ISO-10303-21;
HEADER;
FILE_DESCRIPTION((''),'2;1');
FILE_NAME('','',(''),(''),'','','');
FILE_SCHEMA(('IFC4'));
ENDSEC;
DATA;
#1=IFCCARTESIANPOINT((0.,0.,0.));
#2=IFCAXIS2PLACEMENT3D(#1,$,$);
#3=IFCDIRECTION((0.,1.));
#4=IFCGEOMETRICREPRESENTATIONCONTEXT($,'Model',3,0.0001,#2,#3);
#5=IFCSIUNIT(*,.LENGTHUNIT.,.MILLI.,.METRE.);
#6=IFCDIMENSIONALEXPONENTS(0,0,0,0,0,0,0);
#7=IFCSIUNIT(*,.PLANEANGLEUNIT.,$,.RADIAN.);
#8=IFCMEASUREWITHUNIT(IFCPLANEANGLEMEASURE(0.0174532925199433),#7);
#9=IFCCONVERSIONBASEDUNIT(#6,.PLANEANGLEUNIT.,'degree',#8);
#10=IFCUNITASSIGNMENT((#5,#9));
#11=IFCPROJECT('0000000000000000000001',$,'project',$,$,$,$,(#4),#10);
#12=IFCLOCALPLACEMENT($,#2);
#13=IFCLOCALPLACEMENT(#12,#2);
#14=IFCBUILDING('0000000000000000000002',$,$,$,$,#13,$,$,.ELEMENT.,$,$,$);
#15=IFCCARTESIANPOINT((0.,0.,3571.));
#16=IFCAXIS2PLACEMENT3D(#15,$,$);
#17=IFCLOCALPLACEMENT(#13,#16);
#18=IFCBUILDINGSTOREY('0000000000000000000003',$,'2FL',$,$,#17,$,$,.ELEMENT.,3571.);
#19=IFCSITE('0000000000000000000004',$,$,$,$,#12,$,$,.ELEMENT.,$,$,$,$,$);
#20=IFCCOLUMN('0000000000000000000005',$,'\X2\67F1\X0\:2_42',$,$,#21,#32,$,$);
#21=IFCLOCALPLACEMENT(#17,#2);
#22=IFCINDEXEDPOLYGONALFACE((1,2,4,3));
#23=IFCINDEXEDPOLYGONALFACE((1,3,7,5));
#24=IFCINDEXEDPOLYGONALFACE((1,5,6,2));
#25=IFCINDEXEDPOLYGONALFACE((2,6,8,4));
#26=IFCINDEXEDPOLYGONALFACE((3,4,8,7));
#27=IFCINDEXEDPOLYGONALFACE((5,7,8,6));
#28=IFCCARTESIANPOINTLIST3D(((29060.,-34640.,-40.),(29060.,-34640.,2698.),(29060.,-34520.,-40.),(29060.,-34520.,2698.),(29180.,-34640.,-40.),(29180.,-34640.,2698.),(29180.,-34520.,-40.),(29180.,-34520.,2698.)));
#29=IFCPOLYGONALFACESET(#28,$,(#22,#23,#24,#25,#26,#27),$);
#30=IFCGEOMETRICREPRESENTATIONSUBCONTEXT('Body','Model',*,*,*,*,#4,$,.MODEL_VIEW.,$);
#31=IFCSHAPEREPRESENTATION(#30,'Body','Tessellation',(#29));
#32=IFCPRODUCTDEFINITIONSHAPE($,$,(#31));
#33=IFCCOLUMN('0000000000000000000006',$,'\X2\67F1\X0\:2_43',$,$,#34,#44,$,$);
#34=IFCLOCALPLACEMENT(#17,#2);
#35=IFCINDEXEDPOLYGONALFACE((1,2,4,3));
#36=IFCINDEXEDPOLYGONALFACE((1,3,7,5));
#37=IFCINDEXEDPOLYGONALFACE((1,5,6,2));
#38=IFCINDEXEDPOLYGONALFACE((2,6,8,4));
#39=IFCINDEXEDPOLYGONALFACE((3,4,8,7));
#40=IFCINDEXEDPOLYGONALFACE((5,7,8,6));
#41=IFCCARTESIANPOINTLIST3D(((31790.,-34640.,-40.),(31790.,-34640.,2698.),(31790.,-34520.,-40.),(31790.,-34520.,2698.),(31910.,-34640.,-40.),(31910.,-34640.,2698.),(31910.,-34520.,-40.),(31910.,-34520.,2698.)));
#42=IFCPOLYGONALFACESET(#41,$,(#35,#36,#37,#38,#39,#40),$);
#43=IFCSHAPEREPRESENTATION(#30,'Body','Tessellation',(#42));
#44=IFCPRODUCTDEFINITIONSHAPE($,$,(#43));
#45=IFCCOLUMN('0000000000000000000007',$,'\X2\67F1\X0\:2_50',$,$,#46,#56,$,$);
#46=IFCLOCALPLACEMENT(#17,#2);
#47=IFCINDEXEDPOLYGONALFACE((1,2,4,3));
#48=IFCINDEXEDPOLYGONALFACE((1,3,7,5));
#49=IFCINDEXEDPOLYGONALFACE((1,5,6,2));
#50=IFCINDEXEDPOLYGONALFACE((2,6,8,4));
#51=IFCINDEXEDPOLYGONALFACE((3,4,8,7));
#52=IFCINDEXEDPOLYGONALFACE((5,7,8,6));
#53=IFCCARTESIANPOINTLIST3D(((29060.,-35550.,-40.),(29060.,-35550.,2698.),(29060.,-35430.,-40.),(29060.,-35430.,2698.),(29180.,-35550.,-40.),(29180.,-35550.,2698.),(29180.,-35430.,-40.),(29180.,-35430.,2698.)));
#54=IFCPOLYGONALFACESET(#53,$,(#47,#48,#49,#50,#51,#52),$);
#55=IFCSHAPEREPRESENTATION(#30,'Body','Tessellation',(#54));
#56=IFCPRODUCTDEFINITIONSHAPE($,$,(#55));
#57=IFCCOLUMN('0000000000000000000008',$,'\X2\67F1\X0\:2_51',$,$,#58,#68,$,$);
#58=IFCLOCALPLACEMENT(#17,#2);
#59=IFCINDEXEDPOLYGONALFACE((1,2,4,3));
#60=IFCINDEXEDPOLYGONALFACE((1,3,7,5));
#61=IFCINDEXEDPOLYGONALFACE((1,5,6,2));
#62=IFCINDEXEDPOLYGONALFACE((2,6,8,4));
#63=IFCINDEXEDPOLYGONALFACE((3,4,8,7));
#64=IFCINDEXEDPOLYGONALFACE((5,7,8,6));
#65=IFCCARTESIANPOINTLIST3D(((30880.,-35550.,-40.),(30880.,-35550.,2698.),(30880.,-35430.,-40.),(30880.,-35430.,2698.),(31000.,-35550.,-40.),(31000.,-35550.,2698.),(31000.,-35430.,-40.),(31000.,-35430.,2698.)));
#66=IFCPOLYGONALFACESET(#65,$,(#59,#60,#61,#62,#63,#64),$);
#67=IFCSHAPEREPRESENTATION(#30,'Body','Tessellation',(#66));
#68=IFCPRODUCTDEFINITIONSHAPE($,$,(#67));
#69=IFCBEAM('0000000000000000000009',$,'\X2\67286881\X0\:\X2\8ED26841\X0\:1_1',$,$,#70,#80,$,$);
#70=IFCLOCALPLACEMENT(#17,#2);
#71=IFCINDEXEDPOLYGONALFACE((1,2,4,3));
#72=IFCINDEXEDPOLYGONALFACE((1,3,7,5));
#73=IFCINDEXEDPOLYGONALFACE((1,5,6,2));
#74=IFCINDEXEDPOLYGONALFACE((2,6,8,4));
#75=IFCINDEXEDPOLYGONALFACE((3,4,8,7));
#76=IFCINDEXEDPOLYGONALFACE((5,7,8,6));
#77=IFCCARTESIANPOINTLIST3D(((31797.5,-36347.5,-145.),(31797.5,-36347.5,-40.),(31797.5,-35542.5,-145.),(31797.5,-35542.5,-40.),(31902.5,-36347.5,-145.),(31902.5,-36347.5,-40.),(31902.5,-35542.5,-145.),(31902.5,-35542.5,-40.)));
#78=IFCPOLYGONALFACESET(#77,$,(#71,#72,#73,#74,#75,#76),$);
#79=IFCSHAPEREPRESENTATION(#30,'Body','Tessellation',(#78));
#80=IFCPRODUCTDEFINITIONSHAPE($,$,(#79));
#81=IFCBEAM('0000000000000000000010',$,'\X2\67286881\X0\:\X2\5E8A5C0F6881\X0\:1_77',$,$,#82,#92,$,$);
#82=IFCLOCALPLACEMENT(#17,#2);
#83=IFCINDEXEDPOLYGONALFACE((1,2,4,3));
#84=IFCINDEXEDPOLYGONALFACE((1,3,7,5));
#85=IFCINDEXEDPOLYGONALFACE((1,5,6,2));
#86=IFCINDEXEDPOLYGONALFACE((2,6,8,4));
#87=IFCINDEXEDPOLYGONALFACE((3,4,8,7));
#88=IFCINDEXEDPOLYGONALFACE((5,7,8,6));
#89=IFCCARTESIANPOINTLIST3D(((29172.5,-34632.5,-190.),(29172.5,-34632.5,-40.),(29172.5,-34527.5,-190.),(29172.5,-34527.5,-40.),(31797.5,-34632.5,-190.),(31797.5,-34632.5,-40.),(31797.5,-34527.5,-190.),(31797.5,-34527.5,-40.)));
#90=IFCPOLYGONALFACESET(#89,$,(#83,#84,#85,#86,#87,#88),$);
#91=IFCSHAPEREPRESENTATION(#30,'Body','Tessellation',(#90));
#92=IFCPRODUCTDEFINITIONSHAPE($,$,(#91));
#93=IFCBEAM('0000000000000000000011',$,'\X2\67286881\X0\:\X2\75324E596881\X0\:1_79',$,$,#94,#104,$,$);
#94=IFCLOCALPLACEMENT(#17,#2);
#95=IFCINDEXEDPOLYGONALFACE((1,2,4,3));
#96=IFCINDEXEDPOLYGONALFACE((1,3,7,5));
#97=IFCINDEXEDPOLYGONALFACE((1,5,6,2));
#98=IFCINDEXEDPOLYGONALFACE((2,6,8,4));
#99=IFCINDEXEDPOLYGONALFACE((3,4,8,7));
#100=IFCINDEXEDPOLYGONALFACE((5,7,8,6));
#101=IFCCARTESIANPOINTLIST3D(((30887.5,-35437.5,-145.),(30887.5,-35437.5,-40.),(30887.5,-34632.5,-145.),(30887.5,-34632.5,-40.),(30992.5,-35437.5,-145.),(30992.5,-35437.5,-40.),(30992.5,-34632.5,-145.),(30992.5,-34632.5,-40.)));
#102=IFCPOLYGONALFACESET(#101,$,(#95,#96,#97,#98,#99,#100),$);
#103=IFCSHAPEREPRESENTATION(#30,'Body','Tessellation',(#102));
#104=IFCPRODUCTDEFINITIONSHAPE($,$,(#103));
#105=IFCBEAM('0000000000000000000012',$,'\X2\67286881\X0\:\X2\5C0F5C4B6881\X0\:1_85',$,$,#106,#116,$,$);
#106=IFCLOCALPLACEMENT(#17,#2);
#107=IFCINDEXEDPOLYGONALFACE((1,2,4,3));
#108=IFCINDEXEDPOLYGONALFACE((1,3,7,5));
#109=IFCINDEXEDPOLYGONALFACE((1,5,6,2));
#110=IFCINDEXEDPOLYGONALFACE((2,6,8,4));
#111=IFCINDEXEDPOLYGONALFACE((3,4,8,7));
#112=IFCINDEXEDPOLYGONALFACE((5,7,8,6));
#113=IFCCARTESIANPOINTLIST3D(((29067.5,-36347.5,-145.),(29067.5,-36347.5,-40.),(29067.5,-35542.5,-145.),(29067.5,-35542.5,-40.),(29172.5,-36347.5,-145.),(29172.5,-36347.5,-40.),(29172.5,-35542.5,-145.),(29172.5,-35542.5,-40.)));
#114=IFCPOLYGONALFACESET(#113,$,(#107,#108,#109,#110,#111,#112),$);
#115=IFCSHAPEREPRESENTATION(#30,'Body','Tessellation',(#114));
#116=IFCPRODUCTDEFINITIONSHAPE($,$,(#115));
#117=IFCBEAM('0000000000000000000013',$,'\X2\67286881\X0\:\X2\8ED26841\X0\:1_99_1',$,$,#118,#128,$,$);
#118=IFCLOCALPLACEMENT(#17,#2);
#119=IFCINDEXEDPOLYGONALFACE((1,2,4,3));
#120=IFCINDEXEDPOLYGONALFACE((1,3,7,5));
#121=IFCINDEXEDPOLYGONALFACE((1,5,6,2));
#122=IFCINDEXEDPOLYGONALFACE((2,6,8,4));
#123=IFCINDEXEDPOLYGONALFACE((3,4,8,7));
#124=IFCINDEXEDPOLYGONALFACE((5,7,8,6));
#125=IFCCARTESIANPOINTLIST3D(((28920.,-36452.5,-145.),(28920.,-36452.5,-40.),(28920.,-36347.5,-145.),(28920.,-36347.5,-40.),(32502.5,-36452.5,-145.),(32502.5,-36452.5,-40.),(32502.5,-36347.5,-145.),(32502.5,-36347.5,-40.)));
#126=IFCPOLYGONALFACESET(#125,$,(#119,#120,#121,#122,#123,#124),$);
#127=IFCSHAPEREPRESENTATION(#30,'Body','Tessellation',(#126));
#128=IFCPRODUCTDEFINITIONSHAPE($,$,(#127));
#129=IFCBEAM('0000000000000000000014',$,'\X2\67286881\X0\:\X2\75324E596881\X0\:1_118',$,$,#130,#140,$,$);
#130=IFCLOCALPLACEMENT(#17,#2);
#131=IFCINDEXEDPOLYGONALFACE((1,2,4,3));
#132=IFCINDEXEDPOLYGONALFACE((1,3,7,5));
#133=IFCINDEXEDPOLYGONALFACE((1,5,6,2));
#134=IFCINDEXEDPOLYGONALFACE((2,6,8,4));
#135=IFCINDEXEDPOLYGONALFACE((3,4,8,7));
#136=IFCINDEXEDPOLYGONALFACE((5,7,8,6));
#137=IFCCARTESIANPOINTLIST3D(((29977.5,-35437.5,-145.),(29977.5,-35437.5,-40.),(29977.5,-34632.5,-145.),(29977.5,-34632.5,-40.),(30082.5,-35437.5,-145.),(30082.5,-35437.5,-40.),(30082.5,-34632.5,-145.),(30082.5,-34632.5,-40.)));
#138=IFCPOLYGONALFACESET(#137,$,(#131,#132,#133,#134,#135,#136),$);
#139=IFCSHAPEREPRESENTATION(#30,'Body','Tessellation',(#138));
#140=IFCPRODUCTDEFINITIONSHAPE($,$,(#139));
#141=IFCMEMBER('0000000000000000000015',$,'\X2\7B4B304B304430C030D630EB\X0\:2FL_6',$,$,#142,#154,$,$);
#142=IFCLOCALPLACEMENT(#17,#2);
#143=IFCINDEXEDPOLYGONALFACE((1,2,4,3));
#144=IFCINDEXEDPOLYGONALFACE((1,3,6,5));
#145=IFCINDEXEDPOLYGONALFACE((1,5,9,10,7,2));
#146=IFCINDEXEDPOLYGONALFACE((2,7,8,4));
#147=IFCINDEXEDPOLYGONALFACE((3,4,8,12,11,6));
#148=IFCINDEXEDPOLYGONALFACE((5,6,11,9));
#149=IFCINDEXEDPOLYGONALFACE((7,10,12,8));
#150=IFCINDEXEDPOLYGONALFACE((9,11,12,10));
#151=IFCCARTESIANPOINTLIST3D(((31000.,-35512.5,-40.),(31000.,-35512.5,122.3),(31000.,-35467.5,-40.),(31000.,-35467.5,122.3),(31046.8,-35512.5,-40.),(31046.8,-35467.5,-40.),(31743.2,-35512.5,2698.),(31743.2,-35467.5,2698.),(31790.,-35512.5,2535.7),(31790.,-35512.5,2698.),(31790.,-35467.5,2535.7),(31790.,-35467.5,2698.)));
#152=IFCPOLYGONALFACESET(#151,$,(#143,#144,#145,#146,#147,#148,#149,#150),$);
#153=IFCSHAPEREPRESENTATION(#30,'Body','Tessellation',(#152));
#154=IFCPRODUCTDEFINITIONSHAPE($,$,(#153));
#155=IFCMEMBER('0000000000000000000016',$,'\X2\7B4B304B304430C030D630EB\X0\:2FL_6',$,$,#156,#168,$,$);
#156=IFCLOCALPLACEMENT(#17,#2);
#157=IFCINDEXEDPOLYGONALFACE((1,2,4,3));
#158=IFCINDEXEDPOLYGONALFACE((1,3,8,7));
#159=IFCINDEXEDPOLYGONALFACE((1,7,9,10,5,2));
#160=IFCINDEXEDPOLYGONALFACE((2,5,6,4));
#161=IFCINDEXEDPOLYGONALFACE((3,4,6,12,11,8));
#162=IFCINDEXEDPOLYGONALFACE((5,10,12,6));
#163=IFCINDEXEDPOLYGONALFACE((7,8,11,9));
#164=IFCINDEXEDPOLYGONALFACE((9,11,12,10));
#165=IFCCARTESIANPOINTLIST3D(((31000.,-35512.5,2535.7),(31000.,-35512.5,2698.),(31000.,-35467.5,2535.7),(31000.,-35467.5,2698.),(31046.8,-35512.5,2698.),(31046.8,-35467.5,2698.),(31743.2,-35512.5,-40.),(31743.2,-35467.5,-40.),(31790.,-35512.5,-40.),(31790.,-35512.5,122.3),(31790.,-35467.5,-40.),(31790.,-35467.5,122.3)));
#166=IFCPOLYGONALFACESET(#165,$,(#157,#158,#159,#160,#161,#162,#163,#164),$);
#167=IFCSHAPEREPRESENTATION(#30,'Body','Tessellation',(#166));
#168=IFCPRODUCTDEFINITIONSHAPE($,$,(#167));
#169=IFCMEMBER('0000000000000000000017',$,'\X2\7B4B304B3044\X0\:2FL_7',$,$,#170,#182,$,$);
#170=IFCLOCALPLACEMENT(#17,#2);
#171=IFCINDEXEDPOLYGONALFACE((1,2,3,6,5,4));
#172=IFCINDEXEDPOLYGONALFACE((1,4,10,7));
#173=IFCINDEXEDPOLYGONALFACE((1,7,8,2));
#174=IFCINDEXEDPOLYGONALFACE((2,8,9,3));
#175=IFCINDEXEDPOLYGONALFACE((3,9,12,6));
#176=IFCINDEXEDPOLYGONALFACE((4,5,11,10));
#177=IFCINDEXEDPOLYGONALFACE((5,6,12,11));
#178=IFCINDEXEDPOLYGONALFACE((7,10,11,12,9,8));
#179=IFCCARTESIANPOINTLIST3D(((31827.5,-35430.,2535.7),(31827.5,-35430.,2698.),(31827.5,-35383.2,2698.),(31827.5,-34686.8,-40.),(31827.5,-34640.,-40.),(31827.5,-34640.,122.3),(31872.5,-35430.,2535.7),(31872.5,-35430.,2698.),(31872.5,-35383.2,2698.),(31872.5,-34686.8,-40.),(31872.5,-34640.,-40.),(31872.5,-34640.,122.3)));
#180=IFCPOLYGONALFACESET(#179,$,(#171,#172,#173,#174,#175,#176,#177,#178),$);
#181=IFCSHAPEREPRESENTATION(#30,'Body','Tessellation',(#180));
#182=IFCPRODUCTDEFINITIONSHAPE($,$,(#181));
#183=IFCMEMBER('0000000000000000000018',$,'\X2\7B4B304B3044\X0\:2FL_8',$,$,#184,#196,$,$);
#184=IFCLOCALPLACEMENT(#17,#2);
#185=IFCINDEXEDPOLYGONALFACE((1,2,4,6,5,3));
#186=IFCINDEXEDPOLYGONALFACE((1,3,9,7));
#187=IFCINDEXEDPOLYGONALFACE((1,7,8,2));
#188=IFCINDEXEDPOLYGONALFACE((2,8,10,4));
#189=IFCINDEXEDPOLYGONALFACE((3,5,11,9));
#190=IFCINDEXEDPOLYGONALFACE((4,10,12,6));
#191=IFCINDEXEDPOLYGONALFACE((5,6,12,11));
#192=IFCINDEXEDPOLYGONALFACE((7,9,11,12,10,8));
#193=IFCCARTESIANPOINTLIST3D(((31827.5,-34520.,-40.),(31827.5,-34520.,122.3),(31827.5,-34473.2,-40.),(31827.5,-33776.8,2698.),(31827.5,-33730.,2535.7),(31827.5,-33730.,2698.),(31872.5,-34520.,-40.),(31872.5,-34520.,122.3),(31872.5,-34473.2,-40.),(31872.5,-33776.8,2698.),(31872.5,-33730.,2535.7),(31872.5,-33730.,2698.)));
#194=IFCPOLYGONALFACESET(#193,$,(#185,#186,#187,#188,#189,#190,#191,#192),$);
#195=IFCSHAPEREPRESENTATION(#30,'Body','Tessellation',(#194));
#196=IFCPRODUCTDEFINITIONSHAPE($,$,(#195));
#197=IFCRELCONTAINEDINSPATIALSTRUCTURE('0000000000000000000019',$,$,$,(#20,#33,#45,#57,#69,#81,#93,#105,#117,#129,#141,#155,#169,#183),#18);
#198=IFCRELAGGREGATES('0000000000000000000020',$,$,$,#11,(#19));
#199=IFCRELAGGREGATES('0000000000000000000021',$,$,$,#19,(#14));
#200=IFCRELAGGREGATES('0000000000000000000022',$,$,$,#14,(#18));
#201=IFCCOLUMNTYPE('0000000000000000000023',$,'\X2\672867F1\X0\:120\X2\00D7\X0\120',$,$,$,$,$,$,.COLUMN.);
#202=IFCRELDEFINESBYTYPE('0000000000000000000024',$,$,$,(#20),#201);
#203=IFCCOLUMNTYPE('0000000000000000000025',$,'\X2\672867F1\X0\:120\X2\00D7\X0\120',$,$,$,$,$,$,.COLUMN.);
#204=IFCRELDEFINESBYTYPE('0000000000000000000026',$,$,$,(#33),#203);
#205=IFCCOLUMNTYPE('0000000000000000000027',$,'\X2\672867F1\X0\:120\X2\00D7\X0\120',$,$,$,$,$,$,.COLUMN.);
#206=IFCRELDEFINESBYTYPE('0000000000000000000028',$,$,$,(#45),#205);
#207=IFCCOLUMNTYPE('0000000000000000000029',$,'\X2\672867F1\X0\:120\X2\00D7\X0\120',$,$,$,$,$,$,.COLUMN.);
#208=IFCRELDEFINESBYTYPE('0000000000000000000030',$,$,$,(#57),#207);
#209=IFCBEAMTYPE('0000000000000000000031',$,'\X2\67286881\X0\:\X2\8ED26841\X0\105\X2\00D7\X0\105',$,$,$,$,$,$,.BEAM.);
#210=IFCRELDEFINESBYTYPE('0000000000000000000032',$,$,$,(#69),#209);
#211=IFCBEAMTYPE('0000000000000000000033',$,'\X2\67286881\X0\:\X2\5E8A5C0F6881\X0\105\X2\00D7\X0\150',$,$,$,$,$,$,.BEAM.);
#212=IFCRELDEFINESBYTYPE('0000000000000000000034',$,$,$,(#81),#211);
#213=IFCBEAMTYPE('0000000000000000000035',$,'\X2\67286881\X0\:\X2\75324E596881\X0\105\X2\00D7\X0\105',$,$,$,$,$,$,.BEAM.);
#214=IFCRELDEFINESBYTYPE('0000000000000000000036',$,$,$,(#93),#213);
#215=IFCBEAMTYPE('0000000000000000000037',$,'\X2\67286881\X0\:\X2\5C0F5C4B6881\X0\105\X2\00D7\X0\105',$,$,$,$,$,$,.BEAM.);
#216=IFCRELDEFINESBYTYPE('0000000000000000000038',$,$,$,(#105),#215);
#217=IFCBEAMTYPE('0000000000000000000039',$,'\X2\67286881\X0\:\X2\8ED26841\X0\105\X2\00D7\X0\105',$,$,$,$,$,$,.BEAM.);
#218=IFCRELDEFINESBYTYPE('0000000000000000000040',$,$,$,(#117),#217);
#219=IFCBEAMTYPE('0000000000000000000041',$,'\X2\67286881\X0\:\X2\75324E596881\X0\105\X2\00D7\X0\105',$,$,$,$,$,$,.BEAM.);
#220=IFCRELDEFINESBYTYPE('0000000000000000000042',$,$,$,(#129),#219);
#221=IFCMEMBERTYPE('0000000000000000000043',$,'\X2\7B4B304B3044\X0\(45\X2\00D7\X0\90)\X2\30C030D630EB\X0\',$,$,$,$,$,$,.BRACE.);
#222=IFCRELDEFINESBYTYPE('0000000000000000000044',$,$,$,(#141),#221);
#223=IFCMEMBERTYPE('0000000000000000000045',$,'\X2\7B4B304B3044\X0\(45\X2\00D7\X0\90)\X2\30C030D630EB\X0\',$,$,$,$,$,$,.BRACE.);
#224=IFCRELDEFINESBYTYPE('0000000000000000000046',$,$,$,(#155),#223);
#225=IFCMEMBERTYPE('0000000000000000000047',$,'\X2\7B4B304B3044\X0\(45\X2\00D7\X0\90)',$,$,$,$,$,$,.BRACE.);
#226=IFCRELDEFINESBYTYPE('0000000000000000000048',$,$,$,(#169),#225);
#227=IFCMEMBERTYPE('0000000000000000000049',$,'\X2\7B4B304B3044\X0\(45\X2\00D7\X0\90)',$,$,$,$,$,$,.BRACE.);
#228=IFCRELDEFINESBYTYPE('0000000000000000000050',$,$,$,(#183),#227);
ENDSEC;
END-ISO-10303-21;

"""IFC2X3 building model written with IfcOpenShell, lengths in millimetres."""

from ifc_helpers import new_model, entity, si_unit, converted_unit, direction, frame, origin, origin_with_axes, origin_2d, place, context, subcontext, project, spatial, polyline, rectangle, outline, extrude, type_object, element, save


model = new_model("IFC2X3")

# Units and contexts
model_context = context("Model", 3, precision=0.0001, world=origin(), true_north=direction((0.0, 1.0)))
body_context = subcontext(model_context, "Body", "Model", "MODEL_VIEW")
ifc_project = project(units=[si_unit("LENGTHUNIT", "METRE", prefix="MILLI"), converted_unit("PLANEANGLEUNIT", "degree", entity("IfcPlaneAngleMeasure", 0.0174532925199433), si_unit("PLANEANGLEUNIT", "RADIAN"), dimensions=[0, 0, 0, 0, 0, 0, 0])], contexts=[model_context])

# Site, building, storey
site_placement = place(None, origin())
site = spatial("IfcSite", under=ifc_project, at=site_placement, CompositionType="ELEMENT")
building_placement = place(site_placement, origin())
building = spatial("IfcBuilding", under=site, at=building_placement, CompositionType="ELEMENT")
storey_placement = place(building_placement, frame((0.0, 0.0, 3571.0)))
storey = spatial("IfcBuildingStorey", under=building, at=storey_placement, Name="2FL", CompositionType="ELEMENT", Elevation=3571.0)

# Columns
column_type_1 = type_object("IfcColumnType", Name="木柱:120×120", PredefinedType="COLUMN")
column_1_placement = place(storey_placement, frame((29120.0, -34580.0, -40.0)))
element("IfcColumn", 1, at=column_1_placement, inside=storey, type_object=column_type_1, Name="柱:2_42", context=body_context, shape_type="SweptSolid", body=[
    extrude(rectangle(XDim=120.0, YDim=120.0, at=origin_2d()), origin_with_axes(), (0.0, 0.0, 1.0), 2738.0),
])
column_type_2 = type_object("IfcColumnType", Name="木柱:120×120", PredefinedType="COLUMN")
column_2_placement = place(storey_placement, frame((31850.0, -34580.0, -40.0)))
element("IfcColumn", 2, at=column_2_placement, inside=storey, type_object=column_type_2, Name="柱:2_43", context=body_context, shape_type="SweptSolid", body=[
    extrude(rectangle(XDim=120.0, YDim=120.0, at=origin_2d()), origin_with_axes(), (0.0, 0.0, 1.0), 2738.0),
])
column_type_3 = type_object("IfcColumnType", Name="木柱:120×120", PredefinedType="COLUMN")
column_3_placement = place(storey_placement, frame((29120.0, -35490.0, -40.0)))
element("IfcColumn", 3, at=column_3_placement, inside=storey, type_object=column_type_3, Name="柱:2_50", context=body_context, shape_type="SweptSolid", body=[
    extrude(rectangle(XDim=120.0, YDim=120.0, at=origin_2d()), origin_with_axes(), (0.0, 0.0, 1.0), 2738.0),
])
column_type_4 = type_object("IfcColumnType", Name="木柱:120×120", PredefinedType="COLUMN")
column_4_placement = place(storey_placement, frame((30940.0, -35490.0, -40.0)))
element("IfcColumn", 4, at=column_4_placement, inside=storey, type_object=column_type_4, Name="柱:2_51", context=body_context, shape_type="SweptSolid", body=[
    extrude(rectangle(XDim=120.0, YDim=120.0, at=origin_2d()), origin_with_axes(), (0.0, 0.0, 1.0), 2738.0),
])

# Beams
beam_type_1 = type_object("IfcBeamType", Name="木梁:軒桁105×105", PredefinedType="BEAM")
beam_1_placement = place(storey_placement, frame((31850.0, -35542.5, -92.5), z_axis=(0.0, -1.0, 0.0), x_axis=(1.0, 0.0, 0.0)))
element("IfcBeam", 5, at=beam_1_placement, inside=storey, type_object=beam_type_1, Name="木梁:軒桁:1_1", context=body_context, shape_type="SweptSolid", body=[
    extrude(rectangle(XDim=105.0, YDim=105.0, at=origin_2d()), origin_with_axes(), (0.0, 0.0, 1.0), 805.0),
])
beam_type_2 = type_object("IfcBeamType", Name="木梁:床小梁105×150", PredefinedType="BEAM")
beam_2_placement = place(storey_placement, frame((29172.5, -34580.0, -115.0), z_axis=(1.0, 0.0, 0.0), x_axis=(0.0, 1.0, 0.0)))
element("IfcBeam", 6, at=beam_2_placement, inside=storey, type_object=beam_type_2, Name="木梁:床小梁:1_77", context=body_context, shape_type="SweptSolid", body=[
    extrude(rectangle(XDim=105.0, YDim=150.0, at=origin_2d()), origin_with_axes(), (0.0, 0.0, 1.0), 2625.0),
])
beam_type_3 = type_object("IfcBeamType", Name="木梁:甲乙梁105×105", PredefinedType="BEAM")
beam_3_placement = place(storey_placement, frame((30940.0, -34632.5, -92.5), z_axis=(0.0, -1.0, 0.0), x_axis=(1.0, 0.0, 0.0)))
element("IfcBeam", 7, at=beam_3_placement, inside=storey, type_object=beam_type_3, Name="木梁:甲乙梁:1_79", context=body_context, shape_type="SweptSolid", body=[
    extrude(rectangle(XDim=105.0, YDim=105.0, at=origin_2d()), origin_with_axes(), (0.0, 0.0, 1.0), 805.0),
])
beam_type_4 = type_object("IfcBeamType", Name="木梁:小屋梁105×105", PredefinedType="BEAM")
beam_4_placement = place(storey_placement, frame((29120.0, -35542.5, -92.5), z_axis=(0.0, -1.0, 0.0), x_axis=(1.0, 0.0, 0.0)))
element("IfcBeam", 8, at=beam_4_placement, inside=storey, type_object=beam_type_4, Name="木梁:小屋梁:1_85", context=body_context, shape_type="SweptSolid", body=[
    extrude(rectangle(XDim=105.0, YDim=105.0, at=origin_2d()), origin_with_axes(), (0.0, 0.0, 1.0), 805.0),
])
beam_type_5 = type_object("IfcBeamType", Name="木梁:軒桁105×105", PredefinedType="BEAM")
beam_5_placement = place(storey_placement, frame((28920.0, -36400.0, -92.5), z_axis=(1.0, 0.0, 0.0), x_axis=(0.0, 1.0, 0.0)))
element("IfcBeam", 9, at=beam_5_placement, inside=storey, type_object=beam_type_5, Name="木梁:軒桁:1_99_1", context=body_context, shape_type="SweptSolid", body=[
    extrude(rectangle(XDim=105.0, YDim=105.0, at=origin_2d()), origin_with_axes(), (0.0, 0.0, 1.0), 3582.5),
])
beam_type_6 = type_object("IfcBeamType", Name="木梁:甲乙梁105×105", PredefinedType="BEAM")
beam_6_placement = place(storey_placement, frame((30030.0, -34632.5, -92.5), z_axis=(0.0, -1.0, 0.0), x_axis=(1.0, 0.0, 0.0)))
element("IfcBeam", 10, at=beam_6_placement, inside=storey, type_object=beam_type_6, Name="木梁:甲乙梁:1_118", context=body_context, shape_type="SweptSolid", body=[
    extrude(rectangle(XDim=105.0, YDim=105.0, at=origin_2d()), origin_with_axes(), (0.0, 0.0, 1.0), 805.0),
])

# Members
member_type_1 = type_object("IfcMemberType", Name="筋かい(45×90)ダブル", PredefinedType="BRACE")
member_1_placement = place(storey_placement, frame((31000.0, -35490.0, -40.0), z_axis=(0.277223, 0.0, 0.960806), x_axis=(-0.960806, 0.0, 0.277223)))
element("IfcMember", 11, at=member_1_placement, inside=storey, type_object=member_type_1, Name="筋かいダブル:2FL_6", context=body_context, shape_type="SweptSolid", body=[
    extrude(outline(polyline([(0.0, 0.0), (13.0, -45.0), (2693.7, -45.0), (2849.7, 0.0), (2836.7, 45.0), (156.0, 45.0), (0.0, 0.0)])), frame((0.0, -22.5, 0.0), z_axis=(0.0, 1.0, 0.0), x_axis=(0.0, 0.0, 1.0)), (0.0, 0.0, 1.0), 45.0),
])
member_type_2 = type_object("IfcMemberType", Name="筋かい(45×90)ダブル", PredefinedType="BRACE")
member_2_placement = place(storey_placement, frame((31790.0, -35490.0, -40.0), z_axis=(-0.277223, 0.0, 0.960806), x_axis=(0.960806, 0.0, 0.277223)))
element("IfcMember", 12, at=member_2_placement, inside=storey, type_object=member_type_2, Name="筋かいダブル:2FL_6", context=body_context, shape_type="SweptSolid", body=[
    extrude(outline(polyline([(0.0, 0.0), (13.0, -45.0), (2693.7, -45.0), (2849.7, 0.0), (2836.7, 45.0), (156.0, 45.0), (0.0, 0.0)])), frame((0.0, -22.5, 0.0), z_axis=(0.0, 1.0, 0.0), x_axis=(0.0, 0.0, 1.0)), (0.0, 0.0, 1.0), 45.0),
])
member_type_3 = type_object("IfcMemberType", Name="筋かい(45×90)", PredefinedType="BRACE")
member_3_placement = place(storey_placement, frame((31850.0, -34640.0, -40.0), z_axis=(0.0, -0.277223, 0.960806), x_axis=(0.0, 0.960806, 0.277223)))
element("IfcMember", 13, at=member_3_placement, inside=storey, type_object=member_type_3, Name="筋かい:2FL_7", context=body_context, shape_type="SweptSolid", body=[
    extrude(outline(polyline([(0.0, 0.0), (13.0, -45.0), (2693.7, -45.0), (2849.7, 0.0), (2836.7, 45.0), (156.0, 45.0), (0.0, 0.0)])), frame((0.0, -22.5, 0.0), z_axis=(0.0, 1.0, 0.0), x_axis=(0.0, 0.0, 1.0)), (0.0, 0.0, 1.0), 45.0),
])
member_type_4 = type_object("IfcMemberType", Name="筋かい(45×90)", PredefinedType="BRACE")
member_4_placement = place(storey_placement, frame((31850.0, -34520.0, -40.0), z_axis=(0.0, 0.277223, 0.960806), x_axis=(0.0, -0.960806, 0.277223)))
element("IfcMember", 14, at=member_4_placement, inside=storey, type_object=member_type_4, Name="筋かい:2FL_8", context=body_context, shape_type="SweptSolid", body=[
    extrude(outline(polyline([(0.0, 0.0), (13.0, -45.0), (2693.7, -45.0), (2849.7, 0.0), (2836.7, 45.0), (156.0, 45.0), (0.0, 0.0)])), frame((0.0, -22.5, 0.0), z_axis=(0.0, 1.0, 0.0), x_axis=(0.0, 0.0, 1.0)), (0.0, 0.0, 1.0), 45.0),
])

save(model, "model.ifc")
